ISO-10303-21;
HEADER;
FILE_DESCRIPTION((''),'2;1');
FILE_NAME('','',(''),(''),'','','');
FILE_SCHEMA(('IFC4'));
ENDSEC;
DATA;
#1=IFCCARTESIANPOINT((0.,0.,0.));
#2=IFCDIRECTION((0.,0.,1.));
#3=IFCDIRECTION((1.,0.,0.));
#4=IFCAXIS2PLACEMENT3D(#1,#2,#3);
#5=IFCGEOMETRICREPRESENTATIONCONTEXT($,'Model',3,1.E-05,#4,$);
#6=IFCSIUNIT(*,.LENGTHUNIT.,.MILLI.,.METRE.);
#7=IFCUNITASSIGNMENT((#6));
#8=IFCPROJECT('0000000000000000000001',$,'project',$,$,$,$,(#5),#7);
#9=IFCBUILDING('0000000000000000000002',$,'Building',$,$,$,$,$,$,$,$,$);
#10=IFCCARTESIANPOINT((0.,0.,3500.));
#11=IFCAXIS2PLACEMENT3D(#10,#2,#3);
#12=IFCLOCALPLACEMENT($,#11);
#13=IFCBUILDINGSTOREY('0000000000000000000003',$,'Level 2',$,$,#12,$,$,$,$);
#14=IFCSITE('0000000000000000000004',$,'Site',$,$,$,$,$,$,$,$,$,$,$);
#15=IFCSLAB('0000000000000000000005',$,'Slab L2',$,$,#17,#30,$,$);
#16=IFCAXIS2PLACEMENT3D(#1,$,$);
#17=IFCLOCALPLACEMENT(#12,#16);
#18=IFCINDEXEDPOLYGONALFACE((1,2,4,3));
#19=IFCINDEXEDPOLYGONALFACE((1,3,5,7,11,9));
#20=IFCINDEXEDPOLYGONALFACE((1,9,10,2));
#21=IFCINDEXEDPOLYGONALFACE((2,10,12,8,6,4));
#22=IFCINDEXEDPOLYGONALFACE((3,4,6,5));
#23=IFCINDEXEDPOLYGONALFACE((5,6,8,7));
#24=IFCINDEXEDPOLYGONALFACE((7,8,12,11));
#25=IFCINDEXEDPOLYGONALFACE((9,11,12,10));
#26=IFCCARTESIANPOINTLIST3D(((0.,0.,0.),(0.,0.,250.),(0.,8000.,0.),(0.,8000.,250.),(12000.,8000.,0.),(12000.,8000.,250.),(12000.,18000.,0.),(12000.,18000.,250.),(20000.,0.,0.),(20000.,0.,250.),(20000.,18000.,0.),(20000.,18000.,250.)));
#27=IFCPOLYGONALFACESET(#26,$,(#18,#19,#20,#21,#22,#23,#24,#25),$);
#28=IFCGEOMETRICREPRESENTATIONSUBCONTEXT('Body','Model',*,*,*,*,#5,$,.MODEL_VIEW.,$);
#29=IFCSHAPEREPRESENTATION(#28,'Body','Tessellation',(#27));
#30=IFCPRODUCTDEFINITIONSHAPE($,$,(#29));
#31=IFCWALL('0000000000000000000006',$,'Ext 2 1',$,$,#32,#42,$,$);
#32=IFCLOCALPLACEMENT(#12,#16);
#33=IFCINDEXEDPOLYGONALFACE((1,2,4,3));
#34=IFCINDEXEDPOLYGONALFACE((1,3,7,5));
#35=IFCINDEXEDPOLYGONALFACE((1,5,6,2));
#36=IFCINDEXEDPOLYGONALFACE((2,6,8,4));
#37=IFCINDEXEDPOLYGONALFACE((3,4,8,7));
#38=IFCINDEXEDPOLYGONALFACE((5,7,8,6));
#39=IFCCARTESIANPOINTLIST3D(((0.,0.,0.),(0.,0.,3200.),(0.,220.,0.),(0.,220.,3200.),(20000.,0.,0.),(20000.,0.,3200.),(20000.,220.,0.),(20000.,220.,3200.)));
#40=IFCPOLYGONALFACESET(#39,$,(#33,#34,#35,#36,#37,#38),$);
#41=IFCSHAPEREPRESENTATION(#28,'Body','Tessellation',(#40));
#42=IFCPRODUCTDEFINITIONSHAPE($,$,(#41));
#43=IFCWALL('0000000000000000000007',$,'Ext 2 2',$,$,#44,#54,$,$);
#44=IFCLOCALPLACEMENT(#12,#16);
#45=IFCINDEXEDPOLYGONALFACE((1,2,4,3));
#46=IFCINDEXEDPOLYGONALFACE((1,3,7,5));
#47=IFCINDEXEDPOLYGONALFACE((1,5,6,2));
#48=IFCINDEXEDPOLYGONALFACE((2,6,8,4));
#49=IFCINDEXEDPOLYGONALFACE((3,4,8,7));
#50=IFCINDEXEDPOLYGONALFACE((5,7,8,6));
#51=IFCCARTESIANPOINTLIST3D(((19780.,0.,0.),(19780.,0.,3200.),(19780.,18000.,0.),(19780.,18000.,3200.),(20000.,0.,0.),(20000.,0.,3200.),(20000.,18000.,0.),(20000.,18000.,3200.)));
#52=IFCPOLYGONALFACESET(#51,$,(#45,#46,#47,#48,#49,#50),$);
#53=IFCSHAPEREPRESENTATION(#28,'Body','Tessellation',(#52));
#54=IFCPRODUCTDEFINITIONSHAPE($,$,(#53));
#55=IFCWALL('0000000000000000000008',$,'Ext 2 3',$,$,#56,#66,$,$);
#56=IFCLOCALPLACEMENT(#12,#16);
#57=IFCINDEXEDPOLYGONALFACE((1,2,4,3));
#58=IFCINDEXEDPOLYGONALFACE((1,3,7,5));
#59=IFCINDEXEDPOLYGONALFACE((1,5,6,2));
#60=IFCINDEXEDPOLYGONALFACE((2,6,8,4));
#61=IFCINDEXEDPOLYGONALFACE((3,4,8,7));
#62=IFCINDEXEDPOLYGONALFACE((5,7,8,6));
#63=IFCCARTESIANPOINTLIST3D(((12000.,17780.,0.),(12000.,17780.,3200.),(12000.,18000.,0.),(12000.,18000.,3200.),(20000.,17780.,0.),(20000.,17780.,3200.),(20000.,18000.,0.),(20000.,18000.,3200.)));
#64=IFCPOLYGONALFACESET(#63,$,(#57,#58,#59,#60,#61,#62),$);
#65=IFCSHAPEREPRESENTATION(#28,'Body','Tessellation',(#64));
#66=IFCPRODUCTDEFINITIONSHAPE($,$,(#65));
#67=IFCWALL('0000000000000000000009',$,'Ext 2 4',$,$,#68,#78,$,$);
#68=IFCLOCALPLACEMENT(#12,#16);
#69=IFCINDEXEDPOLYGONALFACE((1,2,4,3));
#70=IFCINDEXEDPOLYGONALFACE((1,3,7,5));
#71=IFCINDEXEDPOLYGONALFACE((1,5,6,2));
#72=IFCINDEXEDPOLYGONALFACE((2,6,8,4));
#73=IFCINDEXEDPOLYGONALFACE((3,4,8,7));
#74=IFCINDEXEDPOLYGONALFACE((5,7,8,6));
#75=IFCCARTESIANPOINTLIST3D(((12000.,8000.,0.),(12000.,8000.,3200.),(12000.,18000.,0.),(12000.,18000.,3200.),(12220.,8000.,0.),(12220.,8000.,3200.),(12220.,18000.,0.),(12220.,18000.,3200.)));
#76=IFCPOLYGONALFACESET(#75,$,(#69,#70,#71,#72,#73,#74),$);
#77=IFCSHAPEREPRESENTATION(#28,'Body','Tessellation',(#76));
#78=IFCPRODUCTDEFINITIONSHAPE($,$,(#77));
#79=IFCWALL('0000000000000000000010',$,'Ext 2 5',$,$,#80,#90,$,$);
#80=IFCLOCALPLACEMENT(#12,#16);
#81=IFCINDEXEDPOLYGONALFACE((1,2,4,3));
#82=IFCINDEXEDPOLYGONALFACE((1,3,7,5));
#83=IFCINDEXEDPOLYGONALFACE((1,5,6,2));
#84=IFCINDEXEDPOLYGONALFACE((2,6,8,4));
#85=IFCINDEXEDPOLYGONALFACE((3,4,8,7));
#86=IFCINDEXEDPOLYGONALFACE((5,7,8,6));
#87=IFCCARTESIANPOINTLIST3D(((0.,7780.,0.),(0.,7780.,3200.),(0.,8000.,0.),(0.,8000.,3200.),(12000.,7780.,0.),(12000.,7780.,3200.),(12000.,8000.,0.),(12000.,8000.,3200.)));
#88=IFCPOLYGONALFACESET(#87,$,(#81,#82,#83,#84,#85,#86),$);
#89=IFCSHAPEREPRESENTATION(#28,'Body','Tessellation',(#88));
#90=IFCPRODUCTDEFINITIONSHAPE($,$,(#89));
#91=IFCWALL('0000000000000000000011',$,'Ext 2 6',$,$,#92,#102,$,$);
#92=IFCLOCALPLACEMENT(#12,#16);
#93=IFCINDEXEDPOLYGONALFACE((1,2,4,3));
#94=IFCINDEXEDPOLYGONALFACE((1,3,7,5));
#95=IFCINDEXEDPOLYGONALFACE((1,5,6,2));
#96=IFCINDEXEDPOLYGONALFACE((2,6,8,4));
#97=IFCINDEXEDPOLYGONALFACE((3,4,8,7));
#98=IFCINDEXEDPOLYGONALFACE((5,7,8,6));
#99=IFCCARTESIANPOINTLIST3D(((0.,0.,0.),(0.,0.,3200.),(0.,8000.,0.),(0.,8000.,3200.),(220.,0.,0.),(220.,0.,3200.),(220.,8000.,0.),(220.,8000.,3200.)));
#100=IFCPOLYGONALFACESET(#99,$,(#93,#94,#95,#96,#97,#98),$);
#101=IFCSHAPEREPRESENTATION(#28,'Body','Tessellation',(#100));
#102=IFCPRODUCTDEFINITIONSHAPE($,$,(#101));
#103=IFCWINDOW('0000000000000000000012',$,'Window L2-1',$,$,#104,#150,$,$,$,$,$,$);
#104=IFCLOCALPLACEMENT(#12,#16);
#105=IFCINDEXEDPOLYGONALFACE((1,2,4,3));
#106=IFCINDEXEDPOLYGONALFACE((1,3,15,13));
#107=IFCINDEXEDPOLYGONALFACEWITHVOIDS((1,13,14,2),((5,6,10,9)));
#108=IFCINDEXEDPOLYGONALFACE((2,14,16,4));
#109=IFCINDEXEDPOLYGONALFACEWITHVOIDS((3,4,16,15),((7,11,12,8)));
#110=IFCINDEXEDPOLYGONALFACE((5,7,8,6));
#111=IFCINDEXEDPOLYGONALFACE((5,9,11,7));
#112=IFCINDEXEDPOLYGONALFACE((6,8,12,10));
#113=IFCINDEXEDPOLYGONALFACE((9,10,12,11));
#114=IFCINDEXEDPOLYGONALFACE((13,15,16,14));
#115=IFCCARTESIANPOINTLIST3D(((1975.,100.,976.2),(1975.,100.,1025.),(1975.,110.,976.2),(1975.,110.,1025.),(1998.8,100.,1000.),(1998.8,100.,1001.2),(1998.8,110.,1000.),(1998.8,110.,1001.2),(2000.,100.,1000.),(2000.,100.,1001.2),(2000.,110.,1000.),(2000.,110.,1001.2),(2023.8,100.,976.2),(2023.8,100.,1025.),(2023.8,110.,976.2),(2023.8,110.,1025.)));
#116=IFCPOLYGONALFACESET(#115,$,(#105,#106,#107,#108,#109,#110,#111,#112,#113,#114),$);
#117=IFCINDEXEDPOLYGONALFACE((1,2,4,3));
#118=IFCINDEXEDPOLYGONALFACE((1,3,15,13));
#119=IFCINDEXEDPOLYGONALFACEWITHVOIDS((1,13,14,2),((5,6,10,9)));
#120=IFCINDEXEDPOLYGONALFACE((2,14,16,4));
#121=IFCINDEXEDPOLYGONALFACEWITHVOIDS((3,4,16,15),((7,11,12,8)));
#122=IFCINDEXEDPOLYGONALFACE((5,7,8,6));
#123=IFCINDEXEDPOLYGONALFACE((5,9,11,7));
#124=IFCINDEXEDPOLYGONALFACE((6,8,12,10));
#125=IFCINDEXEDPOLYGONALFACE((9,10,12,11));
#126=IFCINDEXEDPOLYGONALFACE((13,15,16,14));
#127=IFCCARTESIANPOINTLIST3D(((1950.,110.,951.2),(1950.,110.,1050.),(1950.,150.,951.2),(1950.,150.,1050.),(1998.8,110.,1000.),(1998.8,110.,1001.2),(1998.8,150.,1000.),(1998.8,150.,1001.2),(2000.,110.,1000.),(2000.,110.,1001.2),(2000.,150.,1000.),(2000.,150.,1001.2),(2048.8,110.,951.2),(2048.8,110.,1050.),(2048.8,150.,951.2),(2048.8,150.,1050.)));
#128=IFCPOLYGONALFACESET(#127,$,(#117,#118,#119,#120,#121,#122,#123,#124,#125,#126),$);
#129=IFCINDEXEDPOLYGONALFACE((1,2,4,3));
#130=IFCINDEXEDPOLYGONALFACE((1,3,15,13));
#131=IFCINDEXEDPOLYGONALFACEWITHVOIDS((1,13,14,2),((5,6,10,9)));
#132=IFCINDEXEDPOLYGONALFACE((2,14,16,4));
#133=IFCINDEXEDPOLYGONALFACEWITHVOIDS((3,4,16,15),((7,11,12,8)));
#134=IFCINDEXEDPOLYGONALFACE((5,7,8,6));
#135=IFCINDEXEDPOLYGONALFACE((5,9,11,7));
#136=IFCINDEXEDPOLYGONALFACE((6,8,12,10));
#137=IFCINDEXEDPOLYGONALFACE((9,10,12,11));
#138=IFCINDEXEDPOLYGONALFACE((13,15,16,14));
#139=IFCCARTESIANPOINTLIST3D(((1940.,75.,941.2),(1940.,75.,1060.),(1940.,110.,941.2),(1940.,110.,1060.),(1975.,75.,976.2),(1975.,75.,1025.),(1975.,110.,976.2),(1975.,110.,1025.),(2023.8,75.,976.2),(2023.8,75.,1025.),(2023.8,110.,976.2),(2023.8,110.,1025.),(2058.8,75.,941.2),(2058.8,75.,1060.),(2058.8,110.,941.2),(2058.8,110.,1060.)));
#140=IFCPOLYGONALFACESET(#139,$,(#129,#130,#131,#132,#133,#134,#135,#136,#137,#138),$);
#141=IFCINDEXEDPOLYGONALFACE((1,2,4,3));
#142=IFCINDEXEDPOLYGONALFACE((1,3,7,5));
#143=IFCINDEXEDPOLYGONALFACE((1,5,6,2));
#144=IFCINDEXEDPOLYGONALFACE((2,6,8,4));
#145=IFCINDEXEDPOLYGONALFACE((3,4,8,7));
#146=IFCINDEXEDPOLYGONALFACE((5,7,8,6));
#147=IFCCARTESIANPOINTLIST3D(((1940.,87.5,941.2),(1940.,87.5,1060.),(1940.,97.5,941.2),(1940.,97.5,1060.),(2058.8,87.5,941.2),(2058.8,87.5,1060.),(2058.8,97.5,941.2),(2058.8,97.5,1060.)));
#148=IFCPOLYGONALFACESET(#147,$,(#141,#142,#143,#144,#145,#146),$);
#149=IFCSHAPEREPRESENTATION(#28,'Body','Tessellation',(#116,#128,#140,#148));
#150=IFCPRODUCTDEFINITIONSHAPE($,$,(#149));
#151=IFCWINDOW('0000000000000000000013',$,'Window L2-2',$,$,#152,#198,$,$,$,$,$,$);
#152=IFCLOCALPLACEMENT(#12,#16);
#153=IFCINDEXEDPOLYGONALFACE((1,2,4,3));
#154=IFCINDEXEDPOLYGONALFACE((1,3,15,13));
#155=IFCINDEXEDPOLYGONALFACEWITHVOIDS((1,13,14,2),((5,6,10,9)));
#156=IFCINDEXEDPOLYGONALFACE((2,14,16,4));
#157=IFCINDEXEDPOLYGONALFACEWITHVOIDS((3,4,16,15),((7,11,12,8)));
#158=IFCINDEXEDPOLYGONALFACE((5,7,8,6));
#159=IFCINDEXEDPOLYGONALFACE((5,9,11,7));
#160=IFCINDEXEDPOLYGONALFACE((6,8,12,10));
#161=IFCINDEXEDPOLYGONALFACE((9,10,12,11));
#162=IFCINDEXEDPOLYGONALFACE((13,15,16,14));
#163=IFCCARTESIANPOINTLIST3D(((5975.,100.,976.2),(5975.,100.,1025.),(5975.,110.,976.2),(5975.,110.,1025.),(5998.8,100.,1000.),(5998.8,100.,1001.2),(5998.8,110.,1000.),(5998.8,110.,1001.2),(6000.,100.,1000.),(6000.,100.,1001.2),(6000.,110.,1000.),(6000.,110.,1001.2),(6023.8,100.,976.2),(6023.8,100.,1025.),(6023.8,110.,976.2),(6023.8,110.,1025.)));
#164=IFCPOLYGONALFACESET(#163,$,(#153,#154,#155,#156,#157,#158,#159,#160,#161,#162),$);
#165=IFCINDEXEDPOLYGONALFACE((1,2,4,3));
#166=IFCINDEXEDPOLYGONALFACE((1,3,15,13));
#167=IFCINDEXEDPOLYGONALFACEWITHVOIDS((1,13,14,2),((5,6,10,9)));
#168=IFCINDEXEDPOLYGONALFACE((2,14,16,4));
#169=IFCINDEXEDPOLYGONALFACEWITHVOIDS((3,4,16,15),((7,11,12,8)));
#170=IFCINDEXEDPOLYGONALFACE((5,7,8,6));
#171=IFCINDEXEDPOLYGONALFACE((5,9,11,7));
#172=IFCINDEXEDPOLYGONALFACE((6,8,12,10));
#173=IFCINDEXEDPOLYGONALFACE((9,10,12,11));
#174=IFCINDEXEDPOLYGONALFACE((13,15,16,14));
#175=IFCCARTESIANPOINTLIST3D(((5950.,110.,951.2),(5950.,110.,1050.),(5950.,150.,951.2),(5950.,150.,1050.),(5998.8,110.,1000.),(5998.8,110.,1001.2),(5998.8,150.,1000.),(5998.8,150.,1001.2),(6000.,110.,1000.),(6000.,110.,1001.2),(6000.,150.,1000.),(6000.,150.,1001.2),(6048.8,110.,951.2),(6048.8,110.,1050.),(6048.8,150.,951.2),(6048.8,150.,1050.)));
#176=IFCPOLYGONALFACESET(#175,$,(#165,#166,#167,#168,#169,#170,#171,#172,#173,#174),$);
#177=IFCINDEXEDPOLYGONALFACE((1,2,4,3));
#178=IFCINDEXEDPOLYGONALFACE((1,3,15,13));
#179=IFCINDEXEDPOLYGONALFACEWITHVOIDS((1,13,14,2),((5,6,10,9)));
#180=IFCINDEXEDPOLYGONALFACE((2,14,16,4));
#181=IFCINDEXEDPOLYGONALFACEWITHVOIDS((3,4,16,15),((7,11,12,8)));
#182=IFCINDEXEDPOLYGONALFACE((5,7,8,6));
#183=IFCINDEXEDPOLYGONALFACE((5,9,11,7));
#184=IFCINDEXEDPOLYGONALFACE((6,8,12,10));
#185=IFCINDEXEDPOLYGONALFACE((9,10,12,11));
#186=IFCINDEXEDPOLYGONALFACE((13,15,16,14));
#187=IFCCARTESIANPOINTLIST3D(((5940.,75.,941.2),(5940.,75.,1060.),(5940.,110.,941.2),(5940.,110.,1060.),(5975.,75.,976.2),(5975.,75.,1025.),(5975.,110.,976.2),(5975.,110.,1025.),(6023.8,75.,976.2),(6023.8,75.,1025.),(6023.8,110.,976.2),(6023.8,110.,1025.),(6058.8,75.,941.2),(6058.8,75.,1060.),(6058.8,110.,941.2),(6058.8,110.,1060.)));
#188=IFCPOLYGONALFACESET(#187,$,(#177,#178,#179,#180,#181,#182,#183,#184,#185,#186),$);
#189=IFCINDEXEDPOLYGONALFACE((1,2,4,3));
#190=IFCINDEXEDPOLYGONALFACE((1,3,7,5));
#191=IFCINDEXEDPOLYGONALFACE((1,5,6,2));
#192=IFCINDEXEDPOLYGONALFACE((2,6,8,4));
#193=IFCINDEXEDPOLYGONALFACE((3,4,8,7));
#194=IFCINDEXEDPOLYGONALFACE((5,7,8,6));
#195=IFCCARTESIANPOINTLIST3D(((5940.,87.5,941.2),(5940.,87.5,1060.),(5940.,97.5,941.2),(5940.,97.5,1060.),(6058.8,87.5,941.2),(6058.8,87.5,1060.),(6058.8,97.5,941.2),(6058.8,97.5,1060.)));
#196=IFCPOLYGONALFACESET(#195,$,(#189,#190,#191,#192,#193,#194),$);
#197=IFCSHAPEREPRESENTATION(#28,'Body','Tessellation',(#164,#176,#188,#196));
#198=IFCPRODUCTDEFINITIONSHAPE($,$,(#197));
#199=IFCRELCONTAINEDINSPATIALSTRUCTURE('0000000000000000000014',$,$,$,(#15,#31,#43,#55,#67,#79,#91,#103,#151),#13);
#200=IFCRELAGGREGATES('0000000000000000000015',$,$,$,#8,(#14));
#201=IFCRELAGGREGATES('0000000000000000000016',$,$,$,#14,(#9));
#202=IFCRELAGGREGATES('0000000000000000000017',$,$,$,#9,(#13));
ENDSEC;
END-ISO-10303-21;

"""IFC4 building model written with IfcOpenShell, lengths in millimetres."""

from ifc_helpers import new_model, si_unit, frame, origin_with_axes, place, context, subcontext, project, spatial, line, indexed_curve, outline, extrude, element, save


model = new_model("IFC4")

# Units and contexts
model_context = context("Model", 3, precision=1e-05, world=origin_with_axes())
body_context = subcontext(model_context, "Body", "Model", "MODEL_VIEW")
ifc_project = project(units=[si_unit("LENGTHUNIT", "METRE", prefix="MILLI")], contexts=[model_context])

# Site, building, storey
site = spatial("IfcSite", under=ifc_project, Name="Site")
building = spatial("IfcBuilding", under=site, Name="Building")
storey_placement = place(None, frame((0.0, 0.0, 3500.0), z_axis=(0.0, 0.0, 1.0), x_axis=(1.0, 0.0, 0.0)))
storey = spatial("IfcBuildingStorey", under=building, at=storey_placement, Name="Level 2")

# Slab
slab_placement = place(storey_placement, origin_with_axes())
element("IfcSlab", 1, at=slab_placement, inside=storey, Name="Slab L2", context=body_context, shape_type="SweptSolid", body=[
    extrude(outline(indexed_curve([(0.0, 0.0), (20000.0, 0.0), (20000.0, 18000.0), (12000.0, 18000.0), (12000.0, 8000.0), (0.0, 8000.0), (0.0, 0.0)])), None, (0.0, 0.0, 1.0), 250.0),
])

# Walls
wall_1_placement = place(storey_placement, origin_with_axes())
element("IfcWall", 2, at=wall_1_placement, inside=storey, Name="Ext 2 1", context=body_context, shape_type="SweptSolid", body=[
    extrude(outline(indexed_curve([(0.0, 0.0), (0.0, 220.0), (20000.0, 220.0), (20000.0, 0.0), (0.0, 0.0)], self_intersect=False)), origin_with_axes(), (0.0, 0.0, 1.0), 3200.0),
])
wall_2_placement = place(storey_placement, frame((20000.0, 0.0, 0.0), z_axis=(0.0, 0.0, 1.0), x_axis=(0.0, 1.0, 0.0)))
element("IfcWall", 3, at=wall_2_placement, inside=storey, Name="Ext 2 2", context=body_context, shape_type="SweptSolid", body=[
    extrude(outline(indexed_curve([(0.0, 0.0), (0.0, 220.0), (18000.0, 220.0), (18000.0, 0.0), (0.0, 0.0)], self_intersect=False)), origin_with_axes(), (0.0, 0.0, 1.0), 3200.0),
])
wall_3_placement = place(storey_placement, frame((20000.0, 18000.0, 0.0), z_axis=(0.0, 0.0, 1.0), x_axis=(-1.0, 0.0, 0.0)))
element("IfcWall", 4, at=wall_3_placement, inside=storey, Name="Ext 2 3", context=body_context, shape_type="SweptSolid", body=[
    extrude(outline(indexed_curve([(0.0, 0.0), (0.0, 220.0), (8000.0, 220.0), (8000.0, 0.0), (0.0, 0.0)], self_intersect=False)), origin_with_axes(), (0.0, 0.0, 1.0), 3200.0),
])
wall_4_placement = place(storey_placement, frame((12000.0, 18000.0, 0.0), z_axis=(0.0, 0.0, 1.0), x_axis=(0.0, -1.0, 0.0)))
element("IfcWall", 5, at=wall_4_placement, inside=storey, Name="Ext 2 4", context=body_context, shape_type="SweptSolid", body=[
    extrude(outline(indexed_curve([(0.0, 0.0), (0.0, 220.0), (10000.0, 220.0), (10000.0, 0.0), (0.0, 0.0)], self_intersect=False)), origin_with_axes(), (0.0, 0.0, 1.0), 3200.0),
])
wall_5_placement = place(storey_placement, frame((12000.0, 8000.0, 0.0), z_axis=(0.0, 0.0, 1.0), x_axis=(-1.0, 0.0, 0.0)))
element("IfcWall", 6, at=wall_5_placement, inside=storey, Name="Ext 2 5", context=body_context, shape_type="SweptSolid", body=[
    extrude(outline(indexed_curve([(0.0, 0.0), (0.0, 220.0), (12000.0, 220.0), (12000.0, 0.0), (0.0, 0.0)], self_intersect=False)), origin_with_axes(), (0.0, 0.0, 1.0), 3200.0),
])
wall_6_placement = place(storey_placement, frame((0.0, 8000.0, 0.0), z_axis=(0.0, 0.0, 1.0), x_axis=(0.0, -1.0, 0.0)))
element("IfcWall", 7, at=wall_6_placement, inside=storey, Name="Ext 2 6", context=body_context, shape_type="SweptSolid", body=[
    extrude(outline(indexed_curve([(0.0, 0.0), (0.0, 220.0), (8000.0, 220.0), (8000.0, 0.0), (0.0, 0.0)], self_intersect=False)), origin_with_axes(), (0.0, 0.0, 1.0), 3200.0),
])

# Windows
for number, where, z_axis, x_axis, name in (
    (8, (2000.0, 200.0, 1000.0), (0.0, 0.0, 1.0), (-1.0, 0.0, 0.0), "Window L2-1"),
    (9, (6000.0, 200.0, 1000.0), (0.0, 0.0, 1.0), (-1.0, 0.0, 0.0), "Window L2-2"),
):
    element("IfcWindow", number, at=place(storey_placement, frame(where, z_axis=z_axis, x_axis=x_axis)), inside=storey, Name=name, context=body_context, shape_type="SweptSolid", body=[
        extrude(outline(indexed_curve([(0.0, 0.0), (1.2, 0.0), (1.2, 1.2), (0.0, 1.2)], segments=[line(1, 2, 3, 4, 1)]), holes=[indexed_curve([(25.0, 25.0), (-23.8, 25.0), (-23.8, -23.8), (25.0, -23.8)], segments=[line(1, 2, 3, 4, 1)])]), frame((0.0, 90.0, 0.0), z_axis=(0.0, -1.0, 0.0), x_axis=(1.0, 0.0, 0.0)), (0.0, 0.0, -1.0), 10.0),
        extrude(outline(indexed_curve([(0.0, 0.0), (1.2, 0.0), (1.2, 1.2), (0.0, 1.2)], segments=[line(1, 2, 3, 4, 1)]), holes=[indexed_curve([(50.0, 50.0), (-48.8, 50.0), (-48.8, -48.8), (50.0, -48.8)], segments=[line(1, 2, 3, 4, 1)])]), frame((0.0, 50.0, 0.0), z_axis=(0.0, -1.0, 0.0), x_axis=(1.0, 0.0, 0.0)), (0.0, 0.0, -1.0), 40.0),
        extrude(outline(indexed_curve([(0.0, 0.0), (-48.8, 0.0), (-48.8, -48.8), (0.0, -48.8)], segments=[line(1, 2, 3, 4, 1)]), holes=[indexed_curve([(35.0, 35.0), (-83.8, 35.0), (-83.8, -83.8), (35.0, -83.8)], segments=[line(1, 2, 3, 4, 1)])]), frame((25.0, 90.0, 25.0), z_axis=(0.0, -1.0, 0.0), x_axis=(1.0, 0.0, 0.0)), (0.0, 0.0, -1.0), 35.0),
        extrude(outline(indexed_curve([(35.0, 35.0), (-83.8, 35.0), (-83.8, -83.8), (35.0, -83.8)], segments=[line(1, 2, 3, 4, 1)])), frame((25.0, 102.5, 25.0), z_axis=(0.0, -1.0, 0.0), x_axis=(1.0, 0.0, 0.0)), (0.0, 0.0, -1.0), 10.0),
    ])

save(model, "model.ifc")
